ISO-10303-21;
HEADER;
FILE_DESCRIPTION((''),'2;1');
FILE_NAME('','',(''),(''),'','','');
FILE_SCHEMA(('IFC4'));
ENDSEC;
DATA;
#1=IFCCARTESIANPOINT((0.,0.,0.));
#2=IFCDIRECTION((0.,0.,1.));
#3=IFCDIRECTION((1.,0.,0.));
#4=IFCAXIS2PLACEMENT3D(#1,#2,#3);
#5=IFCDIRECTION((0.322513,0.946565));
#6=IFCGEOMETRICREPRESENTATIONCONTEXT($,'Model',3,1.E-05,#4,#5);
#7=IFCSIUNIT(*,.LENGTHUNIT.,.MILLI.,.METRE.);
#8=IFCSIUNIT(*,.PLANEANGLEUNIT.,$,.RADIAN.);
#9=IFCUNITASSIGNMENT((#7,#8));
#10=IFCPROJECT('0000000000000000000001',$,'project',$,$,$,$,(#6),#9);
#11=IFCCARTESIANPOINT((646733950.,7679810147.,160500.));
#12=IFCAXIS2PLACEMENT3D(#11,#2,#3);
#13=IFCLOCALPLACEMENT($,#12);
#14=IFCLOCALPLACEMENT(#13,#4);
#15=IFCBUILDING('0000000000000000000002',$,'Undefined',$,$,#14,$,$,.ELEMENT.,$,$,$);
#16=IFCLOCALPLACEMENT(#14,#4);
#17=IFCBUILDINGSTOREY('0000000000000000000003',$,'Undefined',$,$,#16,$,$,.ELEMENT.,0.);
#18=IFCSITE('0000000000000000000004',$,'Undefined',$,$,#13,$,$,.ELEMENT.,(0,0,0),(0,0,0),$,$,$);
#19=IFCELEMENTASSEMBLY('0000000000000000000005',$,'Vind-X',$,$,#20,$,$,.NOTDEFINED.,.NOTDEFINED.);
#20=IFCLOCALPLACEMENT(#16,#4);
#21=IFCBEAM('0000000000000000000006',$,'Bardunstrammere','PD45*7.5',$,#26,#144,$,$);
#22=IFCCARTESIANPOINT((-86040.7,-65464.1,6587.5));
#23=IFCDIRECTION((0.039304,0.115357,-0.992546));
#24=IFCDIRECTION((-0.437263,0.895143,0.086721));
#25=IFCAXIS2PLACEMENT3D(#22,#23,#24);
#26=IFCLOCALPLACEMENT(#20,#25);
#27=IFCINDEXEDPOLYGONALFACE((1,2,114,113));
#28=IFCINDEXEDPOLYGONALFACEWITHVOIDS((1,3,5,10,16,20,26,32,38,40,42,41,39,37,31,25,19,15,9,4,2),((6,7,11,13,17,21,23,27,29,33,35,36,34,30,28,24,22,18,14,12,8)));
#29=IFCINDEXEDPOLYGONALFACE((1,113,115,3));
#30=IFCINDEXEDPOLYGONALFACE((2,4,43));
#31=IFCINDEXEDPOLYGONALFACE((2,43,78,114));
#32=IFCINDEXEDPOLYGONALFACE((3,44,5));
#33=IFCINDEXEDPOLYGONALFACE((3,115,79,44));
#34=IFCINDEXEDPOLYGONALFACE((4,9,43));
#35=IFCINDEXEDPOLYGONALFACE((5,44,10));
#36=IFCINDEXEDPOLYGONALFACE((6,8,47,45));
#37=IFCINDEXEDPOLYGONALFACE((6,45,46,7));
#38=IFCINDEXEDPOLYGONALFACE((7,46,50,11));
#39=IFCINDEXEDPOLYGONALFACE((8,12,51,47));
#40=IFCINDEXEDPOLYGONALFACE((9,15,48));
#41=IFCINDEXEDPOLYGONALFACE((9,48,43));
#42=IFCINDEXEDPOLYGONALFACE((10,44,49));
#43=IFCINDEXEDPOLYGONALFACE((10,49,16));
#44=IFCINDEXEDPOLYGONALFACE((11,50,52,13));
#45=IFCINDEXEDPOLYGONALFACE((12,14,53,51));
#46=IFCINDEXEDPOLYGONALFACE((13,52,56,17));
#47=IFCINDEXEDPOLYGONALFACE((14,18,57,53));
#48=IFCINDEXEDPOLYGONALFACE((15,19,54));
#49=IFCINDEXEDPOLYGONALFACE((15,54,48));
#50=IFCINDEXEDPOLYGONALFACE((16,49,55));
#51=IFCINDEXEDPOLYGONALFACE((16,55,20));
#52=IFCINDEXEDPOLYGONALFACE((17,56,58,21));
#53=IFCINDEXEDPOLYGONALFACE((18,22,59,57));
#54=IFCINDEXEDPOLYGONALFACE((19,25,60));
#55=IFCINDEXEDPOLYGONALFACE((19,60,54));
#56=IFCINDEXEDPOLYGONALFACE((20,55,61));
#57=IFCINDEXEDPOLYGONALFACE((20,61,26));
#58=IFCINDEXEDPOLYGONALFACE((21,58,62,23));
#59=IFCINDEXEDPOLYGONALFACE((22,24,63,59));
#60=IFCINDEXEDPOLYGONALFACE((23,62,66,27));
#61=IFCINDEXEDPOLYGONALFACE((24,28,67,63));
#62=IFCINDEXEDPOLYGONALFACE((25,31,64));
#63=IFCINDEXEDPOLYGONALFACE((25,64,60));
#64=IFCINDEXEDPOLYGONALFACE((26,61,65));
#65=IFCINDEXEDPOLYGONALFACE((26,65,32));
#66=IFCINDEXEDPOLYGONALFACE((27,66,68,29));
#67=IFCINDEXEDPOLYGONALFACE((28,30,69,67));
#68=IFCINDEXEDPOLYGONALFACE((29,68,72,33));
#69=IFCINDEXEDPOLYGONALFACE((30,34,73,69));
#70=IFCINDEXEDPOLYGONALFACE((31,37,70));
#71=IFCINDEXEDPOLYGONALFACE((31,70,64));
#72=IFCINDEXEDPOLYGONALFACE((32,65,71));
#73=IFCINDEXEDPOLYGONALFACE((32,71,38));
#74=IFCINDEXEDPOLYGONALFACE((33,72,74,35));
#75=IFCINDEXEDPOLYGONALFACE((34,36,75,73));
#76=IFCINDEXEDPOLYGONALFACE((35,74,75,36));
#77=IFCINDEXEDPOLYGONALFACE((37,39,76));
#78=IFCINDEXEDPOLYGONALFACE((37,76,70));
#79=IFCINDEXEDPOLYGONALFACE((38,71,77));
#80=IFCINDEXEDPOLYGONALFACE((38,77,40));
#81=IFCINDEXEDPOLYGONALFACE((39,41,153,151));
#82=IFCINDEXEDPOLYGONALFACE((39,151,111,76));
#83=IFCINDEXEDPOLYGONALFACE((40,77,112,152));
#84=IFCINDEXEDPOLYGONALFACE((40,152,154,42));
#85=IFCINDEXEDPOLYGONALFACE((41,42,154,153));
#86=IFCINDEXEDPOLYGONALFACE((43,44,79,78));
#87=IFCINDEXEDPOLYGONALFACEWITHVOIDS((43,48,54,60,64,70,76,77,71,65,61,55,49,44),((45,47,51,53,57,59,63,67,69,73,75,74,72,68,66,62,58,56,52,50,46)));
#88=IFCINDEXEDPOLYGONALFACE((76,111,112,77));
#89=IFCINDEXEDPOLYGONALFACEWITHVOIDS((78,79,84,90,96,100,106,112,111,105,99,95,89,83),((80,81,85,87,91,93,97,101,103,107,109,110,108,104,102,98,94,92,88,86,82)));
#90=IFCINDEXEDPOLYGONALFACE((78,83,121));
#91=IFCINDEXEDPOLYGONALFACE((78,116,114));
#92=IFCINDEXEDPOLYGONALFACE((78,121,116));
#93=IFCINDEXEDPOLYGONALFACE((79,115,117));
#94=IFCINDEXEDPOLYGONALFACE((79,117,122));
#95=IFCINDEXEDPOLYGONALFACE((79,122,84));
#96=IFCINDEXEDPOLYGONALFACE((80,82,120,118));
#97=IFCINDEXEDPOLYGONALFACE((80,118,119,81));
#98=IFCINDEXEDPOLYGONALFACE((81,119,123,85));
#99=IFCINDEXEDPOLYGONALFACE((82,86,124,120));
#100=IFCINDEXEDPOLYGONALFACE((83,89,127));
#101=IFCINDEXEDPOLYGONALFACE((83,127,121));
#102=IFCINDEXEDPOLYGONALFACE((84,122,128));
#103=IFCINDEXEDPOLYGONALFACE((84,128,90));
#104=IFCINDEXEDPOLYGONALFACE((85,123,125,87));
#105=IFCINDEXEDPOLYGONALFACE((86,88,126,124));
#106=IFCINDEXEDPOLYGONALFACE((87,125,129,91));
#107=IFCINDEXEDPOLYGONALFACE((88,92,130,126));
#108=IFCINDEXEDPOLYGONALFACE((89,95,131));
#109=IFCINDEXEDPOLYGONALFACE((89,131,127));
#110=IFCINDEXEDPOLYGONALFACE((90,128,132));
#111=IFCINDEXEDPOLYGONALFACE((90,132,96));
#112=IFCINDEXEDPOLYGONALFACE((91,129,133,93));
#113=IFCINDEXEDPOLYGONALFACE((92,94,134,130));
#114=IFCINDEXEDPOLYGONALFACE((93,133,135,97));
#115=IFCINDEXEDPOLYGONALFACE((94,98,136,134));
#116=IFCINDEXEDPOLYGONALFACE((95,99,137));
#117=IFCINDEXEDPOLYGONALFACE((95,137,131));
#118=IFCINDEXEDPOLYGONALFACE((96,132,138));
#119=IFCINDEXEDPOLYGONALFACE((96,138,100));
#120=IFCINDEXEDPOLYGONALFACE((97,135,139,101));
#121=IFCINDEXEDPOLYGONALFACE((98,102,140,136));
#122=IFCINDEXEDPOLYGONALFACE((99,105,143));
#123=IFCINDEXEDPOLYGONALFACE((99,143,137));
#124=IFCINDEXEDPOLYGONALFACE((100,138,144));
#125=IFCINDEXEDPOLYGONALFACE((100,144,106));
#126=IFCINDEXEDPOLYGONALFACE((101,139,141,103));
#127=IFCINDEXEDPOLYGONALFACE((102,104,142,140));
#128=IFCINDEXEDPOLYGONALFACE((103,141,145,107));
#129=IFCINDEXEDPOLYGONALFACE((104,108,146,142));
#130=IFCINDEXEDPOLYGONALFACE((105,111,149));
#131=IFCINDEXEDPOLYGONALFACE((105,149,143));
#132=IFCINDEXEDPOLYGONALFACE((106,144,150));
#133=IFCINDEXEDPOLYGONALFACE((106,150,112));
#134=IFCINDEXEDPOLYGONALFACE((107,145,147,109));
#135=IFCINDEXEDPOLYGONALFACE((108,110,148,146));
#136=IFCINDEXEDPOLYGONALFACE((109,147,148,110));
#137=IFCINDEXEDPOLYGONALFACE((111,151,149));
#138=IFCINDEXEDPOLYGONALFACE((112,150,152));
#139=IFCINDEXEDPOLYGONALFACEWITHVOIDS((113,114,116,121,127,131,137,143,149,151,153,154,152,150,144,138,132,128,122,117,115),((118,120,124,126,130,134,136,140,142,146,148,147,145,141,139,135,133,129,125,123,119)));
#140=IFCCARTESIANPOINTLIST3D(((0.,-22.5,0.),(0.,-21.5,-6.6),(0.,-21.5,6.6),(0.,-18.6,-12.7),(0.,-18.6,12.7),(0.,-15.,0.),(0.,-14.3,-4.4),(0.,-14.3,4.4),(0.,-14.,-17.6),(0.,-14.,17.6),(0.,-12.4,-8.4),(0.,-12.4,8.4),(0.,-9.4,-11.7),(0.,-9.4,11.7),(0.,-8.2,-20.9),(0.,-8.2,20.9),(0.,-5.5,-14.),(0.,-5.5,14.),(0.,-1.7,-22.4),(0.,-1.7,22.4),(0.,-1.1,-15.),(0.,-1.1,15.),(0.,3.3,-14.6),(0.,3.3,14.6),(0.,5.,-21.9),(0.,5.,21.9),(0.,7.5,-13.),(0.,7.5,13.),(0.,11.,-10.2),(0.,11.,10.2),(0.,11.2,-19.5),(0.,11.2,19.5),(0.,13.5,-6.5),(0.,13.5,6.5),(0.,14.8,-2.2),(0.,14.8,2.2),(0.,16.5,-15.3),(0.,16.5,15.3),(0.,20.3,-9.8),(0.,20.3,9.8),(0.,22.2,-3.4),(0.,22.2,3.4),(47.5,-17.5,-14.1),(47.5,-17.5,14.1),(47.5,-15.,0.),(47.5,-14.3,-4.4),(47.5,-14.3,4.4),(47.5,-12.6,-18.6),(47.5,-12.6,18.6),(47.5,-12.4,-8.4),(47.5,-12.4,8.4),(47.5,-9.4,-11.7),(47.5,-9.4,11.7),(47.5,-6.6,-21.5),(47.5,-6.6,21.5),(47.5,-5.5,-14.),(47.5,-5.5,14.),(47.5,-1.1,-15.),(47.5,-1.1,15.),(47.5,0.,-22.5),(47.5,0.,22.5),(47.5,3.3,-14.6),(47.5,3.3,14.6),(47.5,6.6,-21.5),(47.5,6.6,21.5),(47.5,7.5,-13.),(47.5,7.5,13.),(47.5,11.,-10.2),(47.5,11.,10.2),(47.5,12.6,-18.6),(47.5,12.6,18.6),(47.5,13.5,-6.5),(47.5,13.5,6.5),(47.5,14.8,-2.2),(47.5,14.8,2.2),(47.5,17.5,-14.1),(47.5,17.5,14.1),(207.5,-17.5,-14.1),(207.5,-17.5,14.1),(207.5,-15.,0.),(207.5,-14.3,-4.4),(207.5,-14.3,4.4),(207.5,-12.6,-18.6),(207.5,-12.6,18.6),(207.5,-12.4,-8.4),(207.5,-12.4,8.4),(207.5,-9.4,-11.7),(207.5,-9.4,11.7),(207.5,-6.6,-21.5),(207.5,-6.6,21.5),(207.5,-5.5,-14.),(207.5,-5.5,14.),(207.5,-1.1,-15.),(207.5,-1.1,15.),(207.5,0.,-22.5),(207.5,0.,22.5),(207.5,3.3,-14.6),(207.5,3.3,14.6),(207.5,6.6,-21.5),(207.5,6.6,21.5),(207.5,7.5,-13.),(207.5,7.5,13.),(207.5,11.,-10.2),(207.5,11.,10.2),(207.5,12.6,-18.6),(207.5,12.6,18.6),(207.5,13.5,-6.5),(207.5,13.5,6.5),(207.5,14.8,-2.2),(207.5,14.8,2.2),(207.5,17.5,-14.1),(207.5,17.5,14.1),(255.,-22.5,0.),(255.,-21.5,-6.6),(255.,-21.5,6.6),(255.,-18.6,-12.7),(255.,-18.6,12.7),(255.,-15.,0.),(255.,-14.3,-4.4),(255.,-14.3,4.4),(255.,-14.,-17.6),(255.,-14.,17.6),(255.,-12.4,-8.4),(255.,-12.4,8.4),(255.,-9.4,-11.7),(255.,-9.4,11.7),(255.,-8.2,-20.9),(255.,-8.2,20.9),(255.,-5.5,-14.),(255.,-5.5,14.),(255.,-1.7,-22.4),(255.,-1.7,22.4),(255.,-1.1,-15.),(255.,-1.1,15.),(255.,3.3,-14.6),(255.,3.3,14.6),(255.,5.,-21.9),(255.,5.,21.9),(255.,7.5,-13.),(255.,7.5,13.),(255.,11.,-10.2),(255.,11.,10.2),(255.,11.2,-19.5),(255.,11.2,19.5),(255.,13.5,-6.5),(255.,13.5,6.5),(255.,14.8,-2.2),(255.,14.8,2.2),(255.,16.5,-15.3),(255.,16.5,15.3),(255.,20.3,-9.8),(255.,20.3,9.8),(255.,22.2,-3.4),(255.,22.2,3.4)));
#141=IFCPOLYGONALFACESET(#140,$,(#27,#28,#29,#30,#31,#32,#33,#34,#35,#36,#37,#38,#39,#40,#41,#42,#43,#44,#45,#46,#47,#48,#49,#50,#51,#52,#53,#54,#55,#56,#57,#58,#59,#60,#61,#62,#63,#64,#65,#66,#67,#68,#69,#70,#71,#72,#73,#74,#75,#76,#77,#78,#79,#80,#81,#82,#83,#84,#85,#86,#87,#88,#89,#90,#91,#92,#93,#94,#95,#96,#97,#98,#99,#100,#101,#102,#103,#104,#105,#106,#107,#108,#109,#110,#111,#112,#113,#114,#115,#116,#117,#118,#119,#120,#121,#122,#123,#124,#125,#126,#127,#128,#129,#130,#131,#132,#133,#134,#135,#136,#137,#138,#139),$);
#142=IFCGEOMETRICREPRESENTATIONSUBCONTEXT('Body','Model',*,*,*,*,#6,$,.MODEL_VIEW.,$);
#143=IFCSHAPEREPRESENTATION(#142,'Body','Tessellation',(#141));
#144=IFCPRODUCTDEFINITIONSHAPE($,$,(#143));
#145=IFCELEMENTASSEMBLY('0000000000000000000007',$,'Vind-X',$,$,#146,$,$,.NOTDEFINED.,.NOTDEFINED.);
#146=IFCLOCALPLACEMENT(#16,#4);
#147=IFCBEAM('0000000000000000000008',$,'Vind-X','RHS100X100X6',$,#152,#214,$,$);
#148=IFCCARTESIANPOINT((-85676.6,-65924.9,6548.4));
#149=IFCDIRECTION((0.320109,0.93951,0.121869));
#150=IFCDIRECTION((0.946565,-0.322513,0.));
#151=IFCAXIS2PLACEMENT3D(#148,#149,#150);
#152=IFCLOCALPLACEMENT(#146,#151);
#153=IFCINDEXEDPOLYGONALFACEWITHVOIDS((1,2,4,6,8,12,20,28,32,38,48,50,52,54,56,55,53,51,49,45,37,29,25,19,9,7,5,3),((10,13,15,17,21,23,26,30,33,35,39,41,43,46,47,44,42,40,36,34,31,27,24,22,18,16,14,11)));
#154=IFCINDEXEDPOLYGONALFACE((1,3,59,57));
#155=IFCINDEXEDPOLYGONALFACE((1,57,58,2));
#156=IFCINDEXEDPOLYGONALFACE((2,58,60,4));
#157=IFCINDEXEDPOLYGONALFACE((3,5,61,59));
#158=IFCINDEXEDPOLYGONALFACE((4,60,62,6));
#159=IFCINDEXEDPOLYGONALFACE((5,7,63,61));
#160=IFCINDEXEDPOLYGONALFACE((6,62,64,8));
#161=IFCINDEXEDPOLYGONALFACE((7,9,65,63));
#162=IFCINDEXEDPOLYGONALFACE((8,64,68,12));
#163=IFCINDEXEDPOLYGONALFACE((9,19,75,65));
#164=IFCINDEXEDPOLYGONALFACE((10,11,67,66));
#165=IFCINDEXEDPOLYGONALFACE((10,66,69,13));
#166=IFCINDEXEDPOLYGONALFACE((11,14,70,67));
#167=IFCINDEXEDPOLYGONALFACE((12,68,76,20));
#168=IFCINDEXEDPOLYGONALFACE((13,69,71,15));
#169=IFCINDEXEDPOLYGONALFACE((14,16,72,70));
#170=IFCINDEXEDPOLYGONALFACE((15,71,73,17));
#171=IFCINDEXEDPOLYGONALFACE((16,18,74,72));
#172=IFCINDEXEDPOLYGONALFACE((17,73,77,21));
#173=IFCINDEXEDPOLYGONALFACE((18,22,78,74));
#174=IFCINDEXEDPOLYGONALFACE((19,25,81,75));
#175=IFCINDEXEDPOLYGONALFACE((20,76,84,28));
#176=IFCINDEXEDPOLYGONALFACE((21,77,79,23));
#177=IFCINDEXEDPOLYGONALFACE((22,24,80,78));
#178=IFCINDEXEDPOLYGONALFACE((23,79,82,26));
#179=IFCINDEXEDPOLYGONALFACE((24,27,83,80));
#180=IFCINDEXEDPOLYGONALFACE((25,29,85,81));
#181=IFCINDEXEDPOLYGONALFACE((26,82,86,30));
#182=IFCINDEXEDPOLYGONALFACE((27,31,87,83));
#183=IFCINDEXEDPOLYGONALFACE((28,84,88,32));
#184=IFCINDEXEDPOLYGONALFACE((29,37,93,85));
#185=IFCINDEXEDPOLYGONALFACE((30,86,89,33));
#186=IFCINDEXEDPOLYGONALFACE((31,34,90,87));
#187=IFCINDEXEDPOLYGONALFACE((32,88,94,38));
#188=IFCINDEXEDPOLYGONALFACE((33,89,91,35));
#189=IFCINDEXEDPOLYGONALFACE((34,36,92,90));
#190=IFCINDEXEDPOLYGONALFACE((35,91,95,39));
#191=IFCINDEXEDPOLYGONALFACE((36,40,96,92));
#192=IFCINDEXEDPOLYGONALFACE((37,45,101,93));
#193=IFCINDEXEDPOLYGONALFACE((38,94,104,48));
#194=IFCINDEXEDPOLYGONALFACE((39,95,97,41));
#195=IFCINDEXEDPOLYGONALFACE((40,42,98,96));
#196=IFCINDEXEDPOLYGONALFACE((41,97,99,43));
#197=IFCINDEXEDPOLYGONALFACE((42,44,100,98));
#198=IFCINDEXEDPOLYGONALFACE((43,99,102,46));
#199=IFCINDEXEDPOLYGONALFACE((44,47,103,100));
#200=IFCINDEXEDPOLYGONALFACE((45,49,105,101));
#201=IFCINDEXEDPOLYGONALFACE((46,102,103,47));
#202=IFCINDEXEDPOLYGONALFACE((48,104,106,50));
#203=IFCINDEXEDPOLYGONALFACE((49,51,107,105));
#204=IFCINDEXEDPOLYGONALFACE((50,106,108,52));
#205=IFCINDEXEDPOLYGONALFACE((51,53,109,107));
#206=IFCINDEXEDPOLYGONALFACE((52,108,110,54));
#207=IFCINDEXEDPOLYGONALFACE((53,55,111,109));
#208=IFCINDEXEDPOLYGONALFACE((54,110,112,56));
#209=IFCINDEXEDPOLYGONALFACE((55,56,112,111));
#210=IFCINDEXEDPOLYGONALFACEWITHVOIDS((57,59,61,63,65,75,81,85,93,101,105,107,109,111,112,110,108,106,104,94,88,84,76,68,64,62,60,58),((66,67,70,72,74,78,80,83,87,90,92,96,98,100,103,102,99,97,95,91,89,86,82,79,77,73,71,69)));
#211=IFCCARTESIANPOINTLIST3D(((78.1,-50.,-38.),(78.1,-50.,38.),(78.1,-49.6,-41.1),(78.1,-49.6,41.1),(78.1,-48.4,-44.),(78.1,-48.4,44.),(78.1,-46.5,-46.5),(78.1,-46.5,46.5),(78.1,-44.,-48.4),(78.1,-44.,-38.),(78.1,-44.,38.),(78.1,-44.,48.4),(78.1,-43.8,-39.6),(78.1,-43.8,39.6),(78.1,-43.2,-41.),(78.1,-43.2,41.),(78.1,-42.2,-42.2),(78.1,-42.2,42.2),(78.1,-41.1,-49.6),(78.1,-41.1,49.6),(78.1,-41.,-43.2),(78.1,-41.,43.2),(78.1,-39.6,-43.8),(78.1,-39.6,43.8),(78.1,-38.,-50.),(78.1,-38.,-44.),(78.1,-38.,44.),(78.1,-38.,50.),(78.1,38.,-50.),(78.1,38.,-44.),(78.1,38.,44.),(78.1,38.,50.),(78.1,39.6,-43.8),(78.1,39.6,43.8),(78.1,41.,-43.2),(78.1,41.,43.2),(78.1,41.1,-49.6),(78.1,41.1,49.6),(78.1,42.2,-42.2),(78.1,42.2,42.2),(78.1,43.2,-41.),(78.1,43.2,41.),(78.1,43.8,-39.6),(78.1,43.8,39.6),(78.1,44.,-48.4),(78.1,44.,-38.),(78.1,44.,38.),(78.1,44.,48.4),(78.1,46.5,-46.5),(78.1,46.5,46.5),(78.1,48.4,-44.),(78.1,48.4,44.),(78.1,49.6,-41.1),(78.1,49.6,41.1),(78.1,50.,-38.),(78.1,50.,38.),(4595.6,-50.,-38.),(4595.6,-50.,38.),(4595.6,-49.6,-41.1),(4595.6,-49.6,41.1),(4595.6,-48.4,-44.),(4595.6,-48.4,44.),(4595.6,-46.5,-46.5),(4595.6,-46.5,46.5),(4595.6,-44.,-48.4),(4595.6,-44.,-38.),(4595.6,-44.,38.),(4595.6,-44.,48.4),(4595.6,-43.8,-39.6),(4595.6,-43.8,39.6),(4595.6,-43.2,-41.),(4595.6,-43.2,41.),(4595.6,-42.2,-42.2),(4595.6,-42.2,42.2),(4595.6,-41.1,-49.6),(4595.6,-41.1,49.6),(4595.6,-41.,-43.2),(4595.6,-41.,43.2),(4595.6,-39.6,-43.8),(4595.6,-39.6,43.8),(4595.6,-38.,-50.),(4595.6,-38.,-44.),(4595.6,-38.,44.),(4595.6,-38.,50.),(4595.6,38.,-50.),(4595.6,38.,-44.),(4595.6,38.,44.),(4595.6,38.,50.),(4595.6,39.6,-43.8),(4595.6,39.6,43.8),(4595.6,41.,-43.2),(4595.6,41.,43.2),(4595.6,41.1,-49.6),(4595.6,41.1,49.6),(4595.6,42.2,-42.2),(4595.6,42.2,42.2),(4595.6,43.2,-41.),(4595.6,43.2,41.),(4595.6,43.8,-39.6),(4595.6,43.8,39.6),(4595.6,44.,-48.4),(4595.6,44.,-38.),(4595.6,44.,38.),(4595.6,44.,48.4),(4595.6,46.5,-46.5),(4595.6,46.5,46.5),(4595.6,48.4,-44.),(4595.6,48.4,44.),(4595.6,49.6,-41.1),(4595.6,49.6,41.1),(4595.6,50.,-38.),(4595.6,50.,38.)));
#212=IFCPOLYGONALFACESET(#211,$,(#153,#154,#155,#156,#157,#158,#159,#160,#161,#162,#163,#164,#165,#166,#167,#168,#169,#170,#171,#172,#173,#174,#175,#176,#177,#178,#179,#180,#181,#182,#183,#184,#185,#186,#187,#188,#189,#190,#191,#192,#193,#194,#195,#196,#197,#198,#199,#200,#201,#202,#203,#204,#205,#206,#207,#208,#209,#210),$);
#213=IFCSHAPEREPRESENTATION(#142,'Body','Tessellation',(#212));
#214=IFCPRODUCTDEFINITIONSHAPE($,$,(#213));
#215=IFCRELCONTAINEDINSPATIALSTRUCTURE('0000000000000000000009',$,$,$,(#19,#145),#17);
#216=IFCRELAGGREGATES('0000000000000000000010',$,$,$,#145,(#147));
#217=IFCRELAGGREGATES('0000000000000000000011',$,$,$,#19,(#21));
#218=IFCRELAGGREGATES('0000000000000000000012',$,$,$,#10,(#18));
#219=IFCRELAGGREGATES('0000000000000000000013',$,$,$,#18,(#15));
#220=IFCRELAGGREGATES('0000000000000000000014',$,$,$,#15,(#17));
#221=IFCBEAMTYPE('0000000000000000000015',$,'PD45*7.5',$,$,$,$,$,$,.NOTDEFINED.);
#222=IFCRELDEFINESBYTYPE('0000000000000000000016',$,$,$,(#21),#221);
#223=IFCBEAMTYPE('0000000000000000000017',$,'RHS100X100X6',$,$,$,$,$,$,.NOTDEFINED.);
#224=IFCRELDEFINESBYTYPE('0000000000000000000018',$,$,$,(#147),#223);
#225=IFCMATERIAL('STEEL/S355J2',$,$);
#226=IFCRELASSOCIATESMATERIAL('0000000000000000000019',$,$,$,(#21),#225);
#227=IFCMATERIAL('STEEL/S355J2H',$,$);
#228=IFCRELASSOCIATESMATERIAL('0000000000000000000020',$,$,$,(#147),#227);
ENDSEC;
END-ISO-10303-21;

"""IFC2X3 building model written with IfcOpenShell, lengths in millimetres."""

from ifc_helpers import new_model, si_unit, direction, frame, origin_with_axes, origin_2d_with_axis, place, context, subcontext, project, spatial, rectangle, hollow_rectangle, hollow_circle, extrude, boolean, clip, halfspace, material, type_object, element, aggregate, save


model = new_model("IFC2X3")

# Units and contexts
model_context = context("Model", 3, precision=1e-05, world=origin_with_axes(), true_north=direction((0.322513, 0.946565)))
body_context = subcontext(model_context, "Body", "Model", "MODEL_VIEW")
ifc_project = project(units=[si_unit("LENGTHUNIT", "METRE", prefix="MILLI"), si_unit("PLANEANGLEUNIT", "RADIAN")], contexts=[model_context])

# Site, building, storey
site_placement = place(None, frame((646733950.0, 7679810147.0, 160500.0), z_axis=(0.0, 0.0, 1.0), x_axis=(1.0, 0.0, 0.0)))
site = spatial("IfcSite", under=ifc_project, at=site_placement, Name="Undefined", CompositionType="ELEMENT", RefLatitude=(0, 0, 0), RefLongitude=(0, 0, 0))
building_placement = place(site_placement, origin_with_axes())
building = spatial("IfcBuilding", under=site, at=building_placement, Name="Undefined", CompositionType="ELEMENT")
storey_placement = place(building_placement, origin_with_axes())
storey = spatial("IfcBuildingStorey", under=building, at=storey_placement, Name="Undefined", CompositionType="ELEMENT", Elevation=0.0)

# Shared definitions
ifc_material_1 = material(Name="STEEL/S355J2H")

# Element assembly, beam
ifc_material_2 = material(Name="STEEL/S355J2")
beam_type_1 = type_object("IfcBeamType", Name="PD45*7.5", PredefinedType="NOTDEFINED")
assembly_1_placement = place(storey_placement, origin_with_axes())
assembly_1 = element("IfcElementAssembly", 1, at=assembly_1_placement, inside=storey, Name="Vind-X", AssemblyPlace="NOTDEFINED", PredefinedType="NOTDEFINED")
beam_1_placement = place(assembly_1_placement, frame((-86040.7, -65464.1, 6587.5), z_axis=(0.039304, 0.115357, -0.992546), x_axis=(-0.437263, 0.895143, 0.086721)))
beam_1 = element("IfcBeam", 2, at=beam_1_placement, type_object=beam_type_1, material=ifc_material_2, Name="Bardunstrammere", Description="PD45*7.5", context=body_context, shape_type="CSG", body=[
    boolean("DIFFERENCE", extrude(hollow_circle(Radius=22.5, WallThickness=7.5, at=origin_2d_with_axis()), frame((255.0, 0.0, 0.0), z_axis=(-1.0, 0.0, 0.0), x_axis=(0.0, -1.0, 0.0)), (0.0, 0.0, 1.0), 255.0), extrude(rectangle(XDim=35.0, YDim=90.0, at=origin_2d_with_axis()), frame((207.5, 0.0, 0.0), z_axis=(-1.0, 0.0, 0.0), x_axis=(0.0, -1.0, 0.0)), (0.0, 0.0, 1.0), 160.0)),
])

# Element assembly, beam
assembly_2_placement = place(storey_placement, origin_with_axes())
assembly_2 = element("IfcElementAssembly", 3, at=assembly_2_placement, inside=storey, Name="Vind-X", AssemblyPlace="NOTDEFINED", PredefinedType="NOTDEFINED")
beam_type_2 = type_object("IfcBeamType", Name="RHS100X100X6", PredefinedType="NOTDEFINED")
beam_2_placement = place(assembly_2_placement, frame((-85676.6, -65924.9, 6548.4), z_axis=(0.320109, 0.93951, 0.121869), x_axis=(0.946565, -0.322513, 0.0)))
beam_2 = element("IfcBeam", 4, at=beam_2_placement, type_object=beam_type_2, material=ifc_material_1, Name="Vind-X", Description="RHS100X100X6", context=body_context, shape_type="Clipping", body=[
    clip(clip(extrude(hollow_rectangle(XDim=100.0, YDim=100.0, WallThickness=6.0, InnerFilletRadius=6.0, OuterFilletRadius=12.0, at=origin_2d_with_axis()), frame((4674.6, 0.0, 0.0), z_axis=(-1.0, 0.0, 0.0), x_axis=(0.0, -1.0, 0.0)), (0.0, 0.0, 1.0), 4674.6), halfspace(frame((4595.6, 22.5, 0.0), z_axis=(-1.0, 0.0, 0.0), x_axis=(0.0, 0.0, 1.0)), True)), halfspace(frame((78.1, 22.5, 0.0), z_axis=(1.0, 0.0, 0.0), x_axis=(0.0, 0.0, -1.0)), True)),
])

aggregate(assembly_2, [beam_2])
aggregate(assembly_1, [beam_1])

save(model, "model.ifc")
